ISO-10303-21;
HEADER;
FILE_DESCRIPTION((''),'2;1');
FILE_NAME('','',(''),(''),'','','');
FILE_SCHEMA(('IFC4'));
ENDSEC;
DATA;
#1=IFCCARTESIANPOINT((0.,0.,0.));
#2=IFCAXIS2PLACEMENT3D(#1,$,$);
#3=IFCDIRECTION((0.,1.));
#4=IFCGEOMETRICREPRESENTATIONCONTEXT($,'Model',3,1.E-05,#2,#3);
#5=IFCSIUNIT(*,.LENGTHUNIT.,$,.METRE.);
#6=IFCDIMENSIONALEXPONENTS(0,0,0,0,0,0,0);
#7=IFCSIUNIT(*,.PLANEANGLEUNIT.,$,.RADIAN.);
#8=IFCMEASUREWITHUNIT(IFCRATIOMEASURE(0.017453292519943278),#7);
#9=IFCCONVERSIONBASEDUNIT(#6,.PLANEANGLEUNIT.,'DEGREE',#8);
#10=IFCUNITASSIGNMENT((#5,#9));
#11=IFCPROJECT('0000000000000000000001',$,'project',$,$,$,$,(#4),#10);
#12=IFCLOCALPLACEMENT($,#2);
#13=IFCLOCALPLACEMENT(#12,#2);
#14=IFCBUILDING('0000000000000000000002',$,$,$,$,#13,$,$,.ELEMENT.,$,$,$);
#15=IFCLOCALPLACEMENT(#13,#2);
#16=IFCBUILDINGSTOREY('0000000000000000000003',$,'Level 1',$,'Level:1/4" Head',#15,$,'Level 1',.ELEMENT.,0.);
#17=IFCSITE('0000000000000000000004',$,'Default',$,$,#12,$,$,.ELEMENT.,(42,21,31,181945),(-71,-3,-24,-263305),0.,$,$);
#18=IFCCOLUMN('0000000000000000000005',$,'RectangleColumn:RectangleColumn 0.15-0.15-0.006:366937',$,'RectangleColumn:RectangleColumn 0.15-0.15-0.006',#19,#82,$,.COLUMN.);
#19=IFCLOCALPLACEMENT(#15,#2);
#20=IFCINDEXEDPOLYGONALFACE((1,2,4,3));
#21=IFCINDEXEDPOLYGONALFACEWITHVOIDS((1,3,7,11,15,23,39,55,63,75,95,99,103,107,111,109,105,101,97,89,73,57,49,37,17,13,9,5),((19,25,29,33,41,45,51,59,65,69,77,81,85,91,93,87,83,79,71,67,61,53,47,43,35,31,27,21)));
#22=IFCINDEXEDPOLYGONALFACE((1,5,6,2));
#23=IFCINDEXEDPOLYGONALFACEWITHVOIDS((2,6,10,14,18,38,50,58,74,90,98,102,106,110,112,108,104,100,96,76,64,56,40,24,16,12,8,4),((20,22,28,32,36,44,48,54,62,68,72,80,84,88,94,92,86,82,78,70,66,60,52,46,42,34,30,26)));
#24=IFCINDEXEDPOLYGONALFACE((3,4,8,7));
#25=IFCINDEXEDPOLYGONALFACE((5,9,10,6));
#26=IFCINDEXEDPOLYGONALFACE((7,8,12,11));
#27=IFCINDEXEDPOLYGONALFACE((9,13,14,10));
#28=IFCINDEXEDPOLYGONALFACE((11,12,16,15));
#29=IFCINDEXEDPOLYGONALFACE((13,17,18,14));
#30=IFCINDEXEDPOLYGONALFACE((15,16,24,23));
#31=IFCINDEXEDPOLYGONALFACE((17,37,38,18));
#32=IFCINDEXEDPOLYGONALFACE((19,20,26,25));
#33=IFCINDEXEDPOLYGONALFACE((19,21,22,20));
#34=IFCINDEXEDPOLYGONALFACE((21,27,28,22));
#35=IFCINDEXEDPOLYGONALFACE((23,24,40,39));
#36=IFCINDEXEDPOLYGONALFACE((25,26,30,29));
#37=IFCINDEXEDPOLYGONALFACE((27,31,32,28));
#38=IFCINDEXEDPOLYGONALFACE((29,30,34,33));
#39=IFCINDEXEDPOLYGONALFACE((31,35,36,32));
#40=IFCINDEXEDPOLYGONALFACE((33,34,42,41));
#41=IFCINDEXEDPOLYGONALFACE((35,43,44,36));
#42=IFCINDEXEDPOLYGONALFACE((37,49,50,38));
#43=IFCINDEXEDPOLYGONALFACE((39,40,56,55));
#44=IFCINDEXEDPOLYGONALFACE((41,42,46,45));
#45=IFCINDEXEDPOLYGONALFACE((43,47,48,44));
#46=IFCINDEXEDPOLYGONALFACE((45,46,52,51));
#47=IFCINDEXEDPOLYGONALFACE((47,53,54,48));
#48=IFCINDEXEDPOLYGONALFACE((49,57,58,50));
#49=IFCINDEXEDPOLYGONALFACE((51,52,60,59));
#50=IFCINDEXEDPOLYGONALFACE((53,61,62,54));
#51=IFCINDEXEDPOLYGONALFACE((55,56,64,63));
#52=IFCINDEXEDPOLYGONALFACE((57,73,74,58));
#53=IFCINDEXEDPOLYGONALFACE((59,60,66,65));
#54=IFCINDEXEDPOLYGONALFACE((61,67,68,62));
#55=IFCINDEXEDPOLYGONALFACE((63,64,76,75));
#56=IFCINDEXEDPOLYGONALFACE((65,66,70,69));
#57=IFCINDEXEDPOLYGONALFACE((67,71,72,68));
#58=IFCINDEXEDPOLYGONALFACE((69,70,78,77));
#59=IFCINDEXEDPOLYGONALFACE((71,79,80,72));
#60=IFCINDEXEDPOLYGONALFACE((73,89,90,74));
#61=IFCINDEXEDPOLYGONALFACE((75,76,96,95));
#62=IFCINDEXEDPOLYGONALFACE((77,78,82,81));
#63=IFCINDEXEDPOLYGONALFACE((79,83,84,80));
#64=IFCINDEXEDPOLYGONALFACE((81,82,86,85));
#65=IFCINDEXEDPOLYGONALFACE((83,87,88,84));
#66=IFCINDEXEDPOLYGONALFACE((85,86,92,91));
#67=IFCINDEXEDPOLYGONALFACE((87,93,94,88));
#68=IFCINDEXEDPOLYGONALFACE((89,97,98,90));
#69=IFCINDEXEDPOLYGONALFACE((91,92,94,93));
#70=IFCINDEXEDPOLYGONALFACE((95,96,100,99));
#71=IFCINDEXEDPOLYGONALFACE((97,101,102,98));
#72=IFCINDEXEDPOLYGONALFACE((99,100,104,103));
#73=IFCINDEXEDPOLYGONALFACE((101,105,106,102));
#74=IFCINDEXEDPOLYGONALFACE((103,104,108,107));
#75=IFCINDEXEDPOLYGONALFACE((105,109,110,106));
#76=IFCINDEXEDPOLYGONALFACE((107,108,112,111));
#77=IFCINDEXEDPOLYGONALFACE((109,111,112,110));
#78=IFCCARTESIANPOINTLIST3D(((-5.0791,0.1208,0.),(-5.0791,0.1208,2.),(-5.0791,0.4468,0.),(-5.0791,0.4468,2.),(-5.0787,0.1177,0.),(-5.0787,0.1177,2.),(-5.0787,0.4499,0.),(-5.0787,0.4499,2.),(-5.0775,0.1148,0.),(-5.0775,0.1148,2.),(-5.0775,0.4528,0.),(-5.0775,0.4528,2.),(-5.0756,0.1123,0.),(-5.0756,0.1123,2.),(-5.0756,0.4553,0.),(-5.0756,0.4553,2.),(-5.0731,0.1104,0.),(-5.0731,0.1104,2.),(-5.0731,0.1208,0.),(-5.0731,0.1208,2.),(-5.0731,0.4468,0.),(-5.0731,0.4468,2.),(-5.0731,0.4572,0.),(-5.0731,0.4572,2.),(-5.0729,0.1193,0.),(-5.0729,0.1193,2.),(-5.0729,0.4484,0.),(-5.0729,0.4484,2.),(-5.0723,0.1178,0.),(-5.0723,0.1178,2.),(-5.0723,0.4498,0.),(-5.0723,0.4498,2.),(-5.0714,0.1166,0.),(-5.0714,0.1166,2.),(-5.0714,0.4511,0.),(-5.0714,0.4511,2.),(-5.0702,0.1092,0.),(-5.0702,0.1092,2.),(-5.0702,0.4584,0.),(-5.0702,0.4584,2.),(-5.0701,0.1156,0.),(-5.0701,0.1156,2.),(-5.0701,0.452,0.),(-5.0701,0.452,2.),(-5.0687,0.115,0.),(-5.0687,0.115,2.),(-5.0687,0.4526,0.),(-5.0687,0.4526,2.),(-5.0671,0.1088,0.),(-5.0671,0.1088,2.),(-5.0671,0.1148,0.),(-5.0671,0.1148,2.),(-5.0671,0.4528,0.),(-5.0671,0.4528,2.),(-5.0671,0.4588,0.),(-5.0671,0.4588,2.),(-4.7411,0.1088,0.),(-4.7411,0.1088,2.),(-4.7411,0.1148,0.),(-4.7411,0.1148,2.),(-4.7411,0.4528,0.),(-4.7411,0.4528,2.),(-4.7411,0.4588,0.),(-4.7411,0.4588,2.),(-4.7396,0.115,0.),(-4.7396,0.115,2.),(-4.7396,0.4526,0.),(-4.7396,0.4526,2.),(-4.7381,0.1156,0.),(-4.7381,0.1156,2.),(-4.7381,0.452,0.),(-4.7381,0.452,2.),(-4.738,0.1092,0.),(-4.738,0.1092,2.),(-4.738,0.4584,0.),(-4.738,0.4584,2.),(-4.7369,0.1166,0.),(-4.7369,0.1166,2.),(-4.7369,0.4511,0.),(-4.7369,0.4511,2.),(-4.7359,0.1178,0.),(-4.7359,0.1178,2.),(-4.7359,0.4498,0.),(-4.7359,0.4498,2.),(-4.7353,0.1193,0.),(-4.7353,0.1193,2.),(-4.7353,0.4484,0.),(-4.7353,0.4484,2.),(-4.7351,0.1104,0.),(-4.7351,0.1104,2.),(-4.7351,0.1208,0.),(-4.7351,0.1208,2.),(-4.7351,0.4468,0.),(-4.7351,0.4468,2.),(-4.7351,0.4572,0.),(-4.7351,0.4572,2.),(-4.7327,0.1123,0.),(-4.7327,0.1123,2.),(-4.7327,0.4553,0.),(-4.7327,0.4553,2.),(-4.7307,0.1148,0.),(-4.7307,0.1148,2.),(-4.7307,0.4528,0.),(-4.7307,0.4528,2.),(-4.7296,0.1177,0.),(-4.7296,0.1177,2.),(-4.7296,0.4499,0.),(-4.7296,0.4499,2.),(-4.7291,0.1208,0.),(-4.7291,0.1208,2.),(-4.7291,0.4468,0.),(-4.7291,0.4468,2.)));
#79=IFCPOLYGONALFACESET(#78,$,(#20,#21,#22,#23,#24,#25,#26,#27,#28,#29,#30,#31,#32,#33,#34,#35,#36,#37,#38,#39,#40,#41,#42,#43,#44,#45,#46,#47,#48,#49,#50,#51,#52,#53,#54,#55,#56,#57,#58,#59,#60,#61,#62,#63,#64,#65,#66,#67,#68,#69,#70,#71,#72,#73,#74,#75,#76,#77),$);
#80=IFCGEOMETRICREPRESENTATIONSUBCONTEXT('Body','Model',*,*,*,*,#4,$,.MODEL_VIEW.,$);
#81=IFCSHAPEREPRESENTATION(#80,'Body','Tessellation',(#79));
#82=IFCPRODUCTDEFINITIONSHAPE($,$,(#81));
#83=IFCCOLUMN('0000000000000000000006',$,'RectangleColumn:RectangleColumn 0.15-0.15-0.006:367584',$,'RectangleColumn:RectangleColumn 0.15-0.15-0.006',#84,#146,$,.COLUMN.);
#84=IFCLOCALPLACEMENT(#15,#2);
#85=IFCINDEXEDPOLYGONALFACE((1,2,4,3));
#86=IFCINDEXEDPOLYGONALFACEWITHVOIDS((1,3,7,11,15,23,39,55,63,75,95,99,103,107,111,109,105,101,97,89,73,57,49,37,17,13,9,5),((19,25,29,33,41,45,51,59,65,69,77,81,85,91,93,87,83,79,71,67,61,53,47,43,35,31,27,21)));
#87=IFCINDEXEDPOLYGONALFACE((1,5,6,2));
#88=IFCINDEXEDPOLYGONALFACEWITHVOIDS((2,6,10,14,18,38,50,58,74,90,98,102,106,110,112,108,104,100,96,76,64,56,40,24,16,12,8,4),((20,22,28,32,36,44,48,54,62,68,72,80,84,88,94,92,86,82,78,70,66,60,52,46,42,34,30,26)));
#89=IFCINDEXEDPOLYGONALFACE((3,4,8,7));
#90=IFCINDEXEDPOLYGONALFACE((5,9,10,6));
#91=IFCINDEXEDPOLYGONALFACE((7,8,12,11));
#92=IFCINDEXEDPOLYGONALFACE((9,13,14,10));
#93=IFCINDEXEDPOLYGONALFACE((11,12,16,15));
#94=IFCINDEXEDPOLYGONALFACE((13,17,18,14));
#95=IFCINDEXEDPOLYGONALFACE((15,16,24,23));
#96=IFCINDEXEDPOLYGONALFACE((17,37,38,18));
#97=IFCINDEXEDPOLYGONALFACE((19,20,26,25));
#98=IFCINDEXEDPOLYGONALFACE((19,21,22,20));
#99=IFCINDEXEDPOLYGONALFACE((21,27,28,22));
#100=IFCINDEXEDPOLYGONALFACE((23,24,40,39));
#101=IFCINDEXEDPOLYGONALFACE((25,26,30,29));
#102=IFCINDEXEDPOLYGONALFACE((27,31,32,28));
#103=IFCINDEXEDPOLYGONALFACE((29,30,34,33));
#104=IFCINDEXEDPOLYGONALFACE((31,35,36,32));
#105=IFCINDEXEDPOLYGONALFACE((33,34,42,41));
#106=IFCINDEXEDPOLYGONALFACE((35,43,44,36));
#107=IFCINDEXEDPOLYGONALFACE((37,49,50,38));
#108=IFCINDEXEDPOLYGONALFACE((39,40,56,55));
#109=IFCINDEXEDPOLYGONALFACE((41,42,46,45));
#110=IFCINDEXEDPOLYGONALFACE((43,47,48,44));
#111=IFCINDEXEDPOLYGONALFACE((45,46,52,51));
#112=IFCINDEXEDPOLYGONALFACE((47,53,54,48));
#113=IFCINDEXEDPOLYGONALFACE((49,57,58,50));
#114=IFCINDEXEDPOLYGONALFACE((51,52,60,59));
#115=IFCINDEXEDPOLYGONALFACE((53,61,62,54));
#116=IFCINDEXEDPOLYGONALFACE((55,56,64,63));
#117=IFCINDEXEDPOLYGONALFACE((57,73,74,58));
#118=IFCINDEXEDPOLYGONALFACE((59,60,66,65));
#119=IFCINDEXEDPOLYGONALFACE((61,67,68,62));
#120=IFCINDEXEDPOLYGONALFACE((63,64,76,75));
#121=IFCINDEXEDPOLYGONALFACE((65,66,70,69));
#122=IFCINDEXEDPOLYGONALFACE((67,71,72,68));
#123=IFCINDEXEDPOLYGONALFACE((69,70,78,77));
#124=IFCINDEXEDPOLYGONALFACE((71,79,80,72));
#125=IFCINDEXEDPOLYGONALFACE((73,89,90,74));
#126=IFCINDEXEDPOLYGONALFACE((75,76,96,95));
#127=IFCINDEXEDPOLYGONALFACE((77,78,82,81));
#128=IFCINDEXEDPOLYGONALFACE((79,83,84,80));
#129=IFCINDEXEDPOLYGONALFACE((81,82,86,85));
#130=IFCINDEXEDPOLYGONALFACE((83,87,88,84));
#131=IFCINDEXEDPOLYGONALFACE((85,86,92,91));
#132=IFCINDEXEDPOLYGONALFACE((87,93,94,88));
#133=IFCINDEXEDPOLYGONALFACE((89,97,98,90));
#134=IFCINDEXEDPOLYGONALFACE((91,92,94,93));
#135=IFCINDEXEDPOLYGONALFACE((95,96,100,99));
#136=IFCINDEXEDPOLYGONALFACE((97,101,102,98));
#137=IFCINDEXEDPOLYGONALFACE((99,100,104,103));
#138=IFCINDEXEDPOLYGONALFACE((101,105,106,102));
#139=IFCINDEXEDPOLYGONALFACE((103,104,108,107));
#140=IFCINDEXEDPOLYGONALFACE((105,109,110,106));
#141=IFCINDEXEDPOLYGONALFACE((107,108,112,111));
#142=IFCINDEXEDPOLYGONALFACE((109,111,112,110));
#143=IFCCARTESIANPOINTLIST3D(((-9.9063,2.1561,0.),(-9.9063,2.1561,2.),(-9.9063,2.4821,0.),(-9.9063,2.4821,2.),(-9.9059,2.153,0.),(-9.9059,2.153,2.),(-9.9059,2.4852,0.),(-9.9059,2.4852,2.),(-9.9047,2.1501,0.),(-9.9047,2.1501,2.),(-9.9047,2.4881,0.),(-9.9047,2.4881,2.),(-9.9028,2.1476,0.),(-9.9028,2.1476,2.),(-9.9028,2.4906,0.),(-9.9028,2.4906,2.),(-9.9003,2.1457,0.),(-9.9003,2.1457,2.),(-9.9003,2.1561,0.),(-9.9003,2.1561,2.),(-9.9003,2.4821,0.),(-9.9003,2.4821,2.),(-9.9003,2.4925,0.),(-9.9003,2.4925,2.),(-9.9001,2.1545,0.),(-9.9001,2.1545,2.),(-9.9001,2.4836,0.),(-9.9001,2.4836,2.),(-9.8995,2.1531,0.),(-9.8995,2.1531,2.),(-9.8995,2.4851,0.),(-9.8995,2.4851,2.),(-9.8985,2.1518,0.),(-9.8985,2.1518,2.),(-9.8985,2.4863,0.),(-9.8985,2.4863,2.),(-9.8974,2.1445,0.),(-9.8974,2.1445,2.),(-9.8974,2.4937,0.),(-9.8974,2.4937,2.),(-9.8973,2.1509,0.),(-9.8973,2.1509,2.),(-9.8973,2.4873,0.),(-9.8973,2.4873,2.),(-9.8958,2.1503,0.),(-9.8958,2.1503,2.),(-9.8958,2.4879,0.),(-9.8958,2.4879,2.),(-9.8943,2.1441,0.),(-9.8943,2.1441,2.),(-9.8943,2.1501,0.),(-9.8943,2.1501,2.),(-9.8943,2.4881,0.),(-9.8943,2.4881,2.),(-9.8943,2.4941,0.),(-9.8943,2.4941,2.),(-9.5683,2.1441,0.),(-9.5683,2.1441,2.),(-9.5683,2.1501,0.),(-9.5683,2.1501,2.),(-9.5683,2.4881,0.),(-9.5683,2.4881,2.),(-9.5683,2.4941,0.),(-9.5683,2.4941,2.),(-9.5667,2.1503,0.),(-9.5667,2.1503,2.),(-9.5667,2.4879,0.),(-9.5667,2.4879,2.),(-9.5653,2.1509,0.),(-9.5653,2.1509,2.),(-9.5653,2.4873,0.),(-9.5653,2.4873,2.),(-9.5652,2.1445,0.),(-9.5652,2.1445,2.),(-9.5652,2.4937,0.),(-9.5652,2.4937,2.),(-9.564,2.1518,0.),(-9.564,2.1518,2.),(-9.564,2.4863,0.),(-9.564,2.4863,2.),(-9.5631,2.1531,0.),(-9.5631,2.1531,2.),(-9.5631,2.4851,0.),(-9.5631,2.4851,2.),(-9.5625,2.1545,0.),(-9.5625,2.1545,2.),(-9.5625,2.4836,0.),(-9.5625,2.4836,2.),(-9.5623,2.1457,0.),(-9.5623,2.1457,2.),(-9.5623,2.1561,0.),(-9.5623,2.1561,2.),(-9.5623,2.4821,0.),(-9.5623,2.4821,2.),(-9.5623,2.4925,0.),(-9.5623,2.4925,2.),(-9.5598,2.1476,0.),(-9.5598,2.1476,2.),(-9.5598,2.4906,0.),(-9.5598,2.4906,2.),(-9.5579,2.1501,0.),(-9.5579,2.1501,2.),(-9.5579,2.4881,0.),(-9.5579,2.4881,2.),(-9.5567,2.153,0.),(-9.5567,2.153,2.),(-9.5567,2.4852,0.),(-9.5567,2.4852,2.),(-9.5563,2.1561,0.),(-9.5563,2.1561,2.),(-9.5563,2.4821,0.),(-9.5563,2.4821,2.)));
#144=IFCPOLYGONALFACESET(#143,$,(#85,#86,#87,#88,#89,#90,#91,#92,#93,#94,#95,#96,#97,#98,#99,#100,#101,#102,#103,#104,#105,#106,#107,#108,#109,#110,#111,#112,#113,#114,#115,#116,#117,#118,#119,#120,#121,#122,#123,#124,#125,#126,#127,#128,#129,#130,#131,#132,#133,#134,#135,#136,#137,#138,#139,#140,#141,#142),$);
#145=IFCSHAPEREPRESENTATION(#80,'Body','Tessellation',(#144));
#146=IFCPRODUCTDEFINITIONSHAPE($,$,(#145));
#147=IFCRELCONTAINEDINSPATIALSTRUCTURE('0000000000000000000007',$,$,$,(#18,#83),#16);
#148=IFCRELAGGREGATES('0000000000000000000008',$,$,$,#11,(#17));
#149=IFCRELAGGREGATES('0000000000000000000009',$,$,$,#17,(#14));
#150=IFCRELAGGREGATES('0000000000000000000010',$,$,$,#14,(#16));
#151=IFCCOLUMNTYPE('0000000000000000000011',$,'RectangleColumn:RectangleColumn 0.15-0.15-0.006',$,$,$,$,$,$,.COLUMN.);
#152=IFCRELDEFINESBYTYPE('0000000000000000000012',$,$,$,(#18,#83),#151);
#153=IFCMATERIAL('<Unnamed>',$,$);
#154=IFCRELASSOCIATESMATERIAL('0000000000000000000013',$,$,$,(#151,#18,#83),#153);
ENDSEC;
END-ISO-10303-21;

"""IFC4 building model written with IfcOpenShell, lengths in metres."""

from ifc_helpers import new_model, entity, si_unit, converted_unit, direction, frame, origin, place, context, subcontext, project, spatial, line, arc, indexed_curve, outline, extrude, source, transform, mapped, material, type_object, type_shapes, element, save


model = new_model("IFC4")

# Units and contexts
model_context = context("Model", 3, precision=1e-05, world=origin(), true_north=direction((0.0, 1.0)))
body_context = subcontext(model_context, "Body", "Model", "MODEL_VIEW")
ifc_project = project(units=[si_unit("LENGTHUNIT", "METRE"), converted_unit("PLANEANGLEUNIT", "DEGREE", entity("IfcRatioMeasure", 0.017453292519943278), si_unit("PLANEANGLEUNIT", "RADIAN"), dimensions=[0, 0, 0, 0, 0, 0, 0])], contexts=[model_context])

# Site, building, storey
site_placement = place(None, origin())
site = spatial("IfcSite", under=ifc_project, at=site_placement, Name="Default", CompositionType="ELEMENT", RefLatitude=(42, 21, 31, 181945), RefLongitude=(-71, -3, -24, -263305), RefElevation=0.0)
building_placement = place(site_placement, origin())
building = spatial("IfcBuilding", under=site, at=building_placement, CompositionType="ELEMENT")
storey_placement = place(building_placement, origin())
storey = spatial("IfcBuildingStorey", under=building, at=storey_placement, Name="Level 1", ObjectType="Level:1/4\" Head", LongName="Level 1", CompositionType="ELEMENT", Elevation=0.0)

# Columns
ifc_material_1 = material(Name="<Unnamed>")
column_type = type_object("IfcColumnType", Name="RectangleColumn:RectangleColumn 0.15-0.15-0.006", PredefinedType="COLUMN", material=ifc_material_1)
shared_shape = source(origin(), body_context, "Body", "SweptSolid", [
    extrude(outline(indexed_curve([(-0.163, -0.175), (0.163, -0.175), (0.1715, -0.1715), (0.175, -0.163), (0.175, 0.163), (0.1715, 0.1715), (0.163, 0.175), (-0.163, 0.175), (-0.1715, 0.1715), (-0.175, 0.163), (-0.175, -0.163), (-0.1715, -0.1715)], segments=[line(1, 2), arc(2, 3, 4), line(4, 5), arc(5, 6, 7), line(7, 8), arc(8, 9, 10), line(10, 11), arc(11, 12, 1)], self_intersect=False), holes=[indexed_curve([(-0.163, -0.169), (-0.1672, -0.1672), (-0.169, -0.163), (-0.169, 0.163), (-0.1672, 0.1672), (-0.163, 0.169), (0.163, 0.169), (0.1672, 0.1672), (0.169, 0.163), (0.169, -0.163), (0.1672, -0.1672), (0.163, -0.169)], segments=[arc(1, 2, 3), line(3, 4), arc(4, 5, 6), line(6, 7), arc(7, 8, 9), line(9, 10), arc(10, 11, 12), line(12, 1)], self_intersect=False)]), frame((0.0, 0.0, 0.0), z_axis=(0.0, 0.0, 1.0), x_axis=(-1.0, 0.0, 0.0)), (0.0, 0.0, 1.0), 2.0),
])
type_shapes(column_type, [shared_shape])
for number, where, name in (
    (1, (-4.9041, 0.2838, 0.0), "RectangleColumn:RectangleColumn 0.15-0.15-0.006:366937"),
    (2, (-9.7313, 2.3191, 0.0), "RectangleColumn:RectangleColumn 0.15-0.15-0.006:367584"),
):
    element("IfcColumn", number, at=place(storey_placement, frame(where)), inside=storey, type_object=column_type, material=ifc_material_1, Name=name, ObjectType="RectangleColumn:RectangleColumn 0.15-0.15-0.006", PredefinedType="COLUMN", context=body_context, shape_type="MappedRepresentation", body=[
        mapped(shared_shape, transform((0.0, 0.0, 0.0), scale=1.0)),
    ])

save(model, "model.ifc")
